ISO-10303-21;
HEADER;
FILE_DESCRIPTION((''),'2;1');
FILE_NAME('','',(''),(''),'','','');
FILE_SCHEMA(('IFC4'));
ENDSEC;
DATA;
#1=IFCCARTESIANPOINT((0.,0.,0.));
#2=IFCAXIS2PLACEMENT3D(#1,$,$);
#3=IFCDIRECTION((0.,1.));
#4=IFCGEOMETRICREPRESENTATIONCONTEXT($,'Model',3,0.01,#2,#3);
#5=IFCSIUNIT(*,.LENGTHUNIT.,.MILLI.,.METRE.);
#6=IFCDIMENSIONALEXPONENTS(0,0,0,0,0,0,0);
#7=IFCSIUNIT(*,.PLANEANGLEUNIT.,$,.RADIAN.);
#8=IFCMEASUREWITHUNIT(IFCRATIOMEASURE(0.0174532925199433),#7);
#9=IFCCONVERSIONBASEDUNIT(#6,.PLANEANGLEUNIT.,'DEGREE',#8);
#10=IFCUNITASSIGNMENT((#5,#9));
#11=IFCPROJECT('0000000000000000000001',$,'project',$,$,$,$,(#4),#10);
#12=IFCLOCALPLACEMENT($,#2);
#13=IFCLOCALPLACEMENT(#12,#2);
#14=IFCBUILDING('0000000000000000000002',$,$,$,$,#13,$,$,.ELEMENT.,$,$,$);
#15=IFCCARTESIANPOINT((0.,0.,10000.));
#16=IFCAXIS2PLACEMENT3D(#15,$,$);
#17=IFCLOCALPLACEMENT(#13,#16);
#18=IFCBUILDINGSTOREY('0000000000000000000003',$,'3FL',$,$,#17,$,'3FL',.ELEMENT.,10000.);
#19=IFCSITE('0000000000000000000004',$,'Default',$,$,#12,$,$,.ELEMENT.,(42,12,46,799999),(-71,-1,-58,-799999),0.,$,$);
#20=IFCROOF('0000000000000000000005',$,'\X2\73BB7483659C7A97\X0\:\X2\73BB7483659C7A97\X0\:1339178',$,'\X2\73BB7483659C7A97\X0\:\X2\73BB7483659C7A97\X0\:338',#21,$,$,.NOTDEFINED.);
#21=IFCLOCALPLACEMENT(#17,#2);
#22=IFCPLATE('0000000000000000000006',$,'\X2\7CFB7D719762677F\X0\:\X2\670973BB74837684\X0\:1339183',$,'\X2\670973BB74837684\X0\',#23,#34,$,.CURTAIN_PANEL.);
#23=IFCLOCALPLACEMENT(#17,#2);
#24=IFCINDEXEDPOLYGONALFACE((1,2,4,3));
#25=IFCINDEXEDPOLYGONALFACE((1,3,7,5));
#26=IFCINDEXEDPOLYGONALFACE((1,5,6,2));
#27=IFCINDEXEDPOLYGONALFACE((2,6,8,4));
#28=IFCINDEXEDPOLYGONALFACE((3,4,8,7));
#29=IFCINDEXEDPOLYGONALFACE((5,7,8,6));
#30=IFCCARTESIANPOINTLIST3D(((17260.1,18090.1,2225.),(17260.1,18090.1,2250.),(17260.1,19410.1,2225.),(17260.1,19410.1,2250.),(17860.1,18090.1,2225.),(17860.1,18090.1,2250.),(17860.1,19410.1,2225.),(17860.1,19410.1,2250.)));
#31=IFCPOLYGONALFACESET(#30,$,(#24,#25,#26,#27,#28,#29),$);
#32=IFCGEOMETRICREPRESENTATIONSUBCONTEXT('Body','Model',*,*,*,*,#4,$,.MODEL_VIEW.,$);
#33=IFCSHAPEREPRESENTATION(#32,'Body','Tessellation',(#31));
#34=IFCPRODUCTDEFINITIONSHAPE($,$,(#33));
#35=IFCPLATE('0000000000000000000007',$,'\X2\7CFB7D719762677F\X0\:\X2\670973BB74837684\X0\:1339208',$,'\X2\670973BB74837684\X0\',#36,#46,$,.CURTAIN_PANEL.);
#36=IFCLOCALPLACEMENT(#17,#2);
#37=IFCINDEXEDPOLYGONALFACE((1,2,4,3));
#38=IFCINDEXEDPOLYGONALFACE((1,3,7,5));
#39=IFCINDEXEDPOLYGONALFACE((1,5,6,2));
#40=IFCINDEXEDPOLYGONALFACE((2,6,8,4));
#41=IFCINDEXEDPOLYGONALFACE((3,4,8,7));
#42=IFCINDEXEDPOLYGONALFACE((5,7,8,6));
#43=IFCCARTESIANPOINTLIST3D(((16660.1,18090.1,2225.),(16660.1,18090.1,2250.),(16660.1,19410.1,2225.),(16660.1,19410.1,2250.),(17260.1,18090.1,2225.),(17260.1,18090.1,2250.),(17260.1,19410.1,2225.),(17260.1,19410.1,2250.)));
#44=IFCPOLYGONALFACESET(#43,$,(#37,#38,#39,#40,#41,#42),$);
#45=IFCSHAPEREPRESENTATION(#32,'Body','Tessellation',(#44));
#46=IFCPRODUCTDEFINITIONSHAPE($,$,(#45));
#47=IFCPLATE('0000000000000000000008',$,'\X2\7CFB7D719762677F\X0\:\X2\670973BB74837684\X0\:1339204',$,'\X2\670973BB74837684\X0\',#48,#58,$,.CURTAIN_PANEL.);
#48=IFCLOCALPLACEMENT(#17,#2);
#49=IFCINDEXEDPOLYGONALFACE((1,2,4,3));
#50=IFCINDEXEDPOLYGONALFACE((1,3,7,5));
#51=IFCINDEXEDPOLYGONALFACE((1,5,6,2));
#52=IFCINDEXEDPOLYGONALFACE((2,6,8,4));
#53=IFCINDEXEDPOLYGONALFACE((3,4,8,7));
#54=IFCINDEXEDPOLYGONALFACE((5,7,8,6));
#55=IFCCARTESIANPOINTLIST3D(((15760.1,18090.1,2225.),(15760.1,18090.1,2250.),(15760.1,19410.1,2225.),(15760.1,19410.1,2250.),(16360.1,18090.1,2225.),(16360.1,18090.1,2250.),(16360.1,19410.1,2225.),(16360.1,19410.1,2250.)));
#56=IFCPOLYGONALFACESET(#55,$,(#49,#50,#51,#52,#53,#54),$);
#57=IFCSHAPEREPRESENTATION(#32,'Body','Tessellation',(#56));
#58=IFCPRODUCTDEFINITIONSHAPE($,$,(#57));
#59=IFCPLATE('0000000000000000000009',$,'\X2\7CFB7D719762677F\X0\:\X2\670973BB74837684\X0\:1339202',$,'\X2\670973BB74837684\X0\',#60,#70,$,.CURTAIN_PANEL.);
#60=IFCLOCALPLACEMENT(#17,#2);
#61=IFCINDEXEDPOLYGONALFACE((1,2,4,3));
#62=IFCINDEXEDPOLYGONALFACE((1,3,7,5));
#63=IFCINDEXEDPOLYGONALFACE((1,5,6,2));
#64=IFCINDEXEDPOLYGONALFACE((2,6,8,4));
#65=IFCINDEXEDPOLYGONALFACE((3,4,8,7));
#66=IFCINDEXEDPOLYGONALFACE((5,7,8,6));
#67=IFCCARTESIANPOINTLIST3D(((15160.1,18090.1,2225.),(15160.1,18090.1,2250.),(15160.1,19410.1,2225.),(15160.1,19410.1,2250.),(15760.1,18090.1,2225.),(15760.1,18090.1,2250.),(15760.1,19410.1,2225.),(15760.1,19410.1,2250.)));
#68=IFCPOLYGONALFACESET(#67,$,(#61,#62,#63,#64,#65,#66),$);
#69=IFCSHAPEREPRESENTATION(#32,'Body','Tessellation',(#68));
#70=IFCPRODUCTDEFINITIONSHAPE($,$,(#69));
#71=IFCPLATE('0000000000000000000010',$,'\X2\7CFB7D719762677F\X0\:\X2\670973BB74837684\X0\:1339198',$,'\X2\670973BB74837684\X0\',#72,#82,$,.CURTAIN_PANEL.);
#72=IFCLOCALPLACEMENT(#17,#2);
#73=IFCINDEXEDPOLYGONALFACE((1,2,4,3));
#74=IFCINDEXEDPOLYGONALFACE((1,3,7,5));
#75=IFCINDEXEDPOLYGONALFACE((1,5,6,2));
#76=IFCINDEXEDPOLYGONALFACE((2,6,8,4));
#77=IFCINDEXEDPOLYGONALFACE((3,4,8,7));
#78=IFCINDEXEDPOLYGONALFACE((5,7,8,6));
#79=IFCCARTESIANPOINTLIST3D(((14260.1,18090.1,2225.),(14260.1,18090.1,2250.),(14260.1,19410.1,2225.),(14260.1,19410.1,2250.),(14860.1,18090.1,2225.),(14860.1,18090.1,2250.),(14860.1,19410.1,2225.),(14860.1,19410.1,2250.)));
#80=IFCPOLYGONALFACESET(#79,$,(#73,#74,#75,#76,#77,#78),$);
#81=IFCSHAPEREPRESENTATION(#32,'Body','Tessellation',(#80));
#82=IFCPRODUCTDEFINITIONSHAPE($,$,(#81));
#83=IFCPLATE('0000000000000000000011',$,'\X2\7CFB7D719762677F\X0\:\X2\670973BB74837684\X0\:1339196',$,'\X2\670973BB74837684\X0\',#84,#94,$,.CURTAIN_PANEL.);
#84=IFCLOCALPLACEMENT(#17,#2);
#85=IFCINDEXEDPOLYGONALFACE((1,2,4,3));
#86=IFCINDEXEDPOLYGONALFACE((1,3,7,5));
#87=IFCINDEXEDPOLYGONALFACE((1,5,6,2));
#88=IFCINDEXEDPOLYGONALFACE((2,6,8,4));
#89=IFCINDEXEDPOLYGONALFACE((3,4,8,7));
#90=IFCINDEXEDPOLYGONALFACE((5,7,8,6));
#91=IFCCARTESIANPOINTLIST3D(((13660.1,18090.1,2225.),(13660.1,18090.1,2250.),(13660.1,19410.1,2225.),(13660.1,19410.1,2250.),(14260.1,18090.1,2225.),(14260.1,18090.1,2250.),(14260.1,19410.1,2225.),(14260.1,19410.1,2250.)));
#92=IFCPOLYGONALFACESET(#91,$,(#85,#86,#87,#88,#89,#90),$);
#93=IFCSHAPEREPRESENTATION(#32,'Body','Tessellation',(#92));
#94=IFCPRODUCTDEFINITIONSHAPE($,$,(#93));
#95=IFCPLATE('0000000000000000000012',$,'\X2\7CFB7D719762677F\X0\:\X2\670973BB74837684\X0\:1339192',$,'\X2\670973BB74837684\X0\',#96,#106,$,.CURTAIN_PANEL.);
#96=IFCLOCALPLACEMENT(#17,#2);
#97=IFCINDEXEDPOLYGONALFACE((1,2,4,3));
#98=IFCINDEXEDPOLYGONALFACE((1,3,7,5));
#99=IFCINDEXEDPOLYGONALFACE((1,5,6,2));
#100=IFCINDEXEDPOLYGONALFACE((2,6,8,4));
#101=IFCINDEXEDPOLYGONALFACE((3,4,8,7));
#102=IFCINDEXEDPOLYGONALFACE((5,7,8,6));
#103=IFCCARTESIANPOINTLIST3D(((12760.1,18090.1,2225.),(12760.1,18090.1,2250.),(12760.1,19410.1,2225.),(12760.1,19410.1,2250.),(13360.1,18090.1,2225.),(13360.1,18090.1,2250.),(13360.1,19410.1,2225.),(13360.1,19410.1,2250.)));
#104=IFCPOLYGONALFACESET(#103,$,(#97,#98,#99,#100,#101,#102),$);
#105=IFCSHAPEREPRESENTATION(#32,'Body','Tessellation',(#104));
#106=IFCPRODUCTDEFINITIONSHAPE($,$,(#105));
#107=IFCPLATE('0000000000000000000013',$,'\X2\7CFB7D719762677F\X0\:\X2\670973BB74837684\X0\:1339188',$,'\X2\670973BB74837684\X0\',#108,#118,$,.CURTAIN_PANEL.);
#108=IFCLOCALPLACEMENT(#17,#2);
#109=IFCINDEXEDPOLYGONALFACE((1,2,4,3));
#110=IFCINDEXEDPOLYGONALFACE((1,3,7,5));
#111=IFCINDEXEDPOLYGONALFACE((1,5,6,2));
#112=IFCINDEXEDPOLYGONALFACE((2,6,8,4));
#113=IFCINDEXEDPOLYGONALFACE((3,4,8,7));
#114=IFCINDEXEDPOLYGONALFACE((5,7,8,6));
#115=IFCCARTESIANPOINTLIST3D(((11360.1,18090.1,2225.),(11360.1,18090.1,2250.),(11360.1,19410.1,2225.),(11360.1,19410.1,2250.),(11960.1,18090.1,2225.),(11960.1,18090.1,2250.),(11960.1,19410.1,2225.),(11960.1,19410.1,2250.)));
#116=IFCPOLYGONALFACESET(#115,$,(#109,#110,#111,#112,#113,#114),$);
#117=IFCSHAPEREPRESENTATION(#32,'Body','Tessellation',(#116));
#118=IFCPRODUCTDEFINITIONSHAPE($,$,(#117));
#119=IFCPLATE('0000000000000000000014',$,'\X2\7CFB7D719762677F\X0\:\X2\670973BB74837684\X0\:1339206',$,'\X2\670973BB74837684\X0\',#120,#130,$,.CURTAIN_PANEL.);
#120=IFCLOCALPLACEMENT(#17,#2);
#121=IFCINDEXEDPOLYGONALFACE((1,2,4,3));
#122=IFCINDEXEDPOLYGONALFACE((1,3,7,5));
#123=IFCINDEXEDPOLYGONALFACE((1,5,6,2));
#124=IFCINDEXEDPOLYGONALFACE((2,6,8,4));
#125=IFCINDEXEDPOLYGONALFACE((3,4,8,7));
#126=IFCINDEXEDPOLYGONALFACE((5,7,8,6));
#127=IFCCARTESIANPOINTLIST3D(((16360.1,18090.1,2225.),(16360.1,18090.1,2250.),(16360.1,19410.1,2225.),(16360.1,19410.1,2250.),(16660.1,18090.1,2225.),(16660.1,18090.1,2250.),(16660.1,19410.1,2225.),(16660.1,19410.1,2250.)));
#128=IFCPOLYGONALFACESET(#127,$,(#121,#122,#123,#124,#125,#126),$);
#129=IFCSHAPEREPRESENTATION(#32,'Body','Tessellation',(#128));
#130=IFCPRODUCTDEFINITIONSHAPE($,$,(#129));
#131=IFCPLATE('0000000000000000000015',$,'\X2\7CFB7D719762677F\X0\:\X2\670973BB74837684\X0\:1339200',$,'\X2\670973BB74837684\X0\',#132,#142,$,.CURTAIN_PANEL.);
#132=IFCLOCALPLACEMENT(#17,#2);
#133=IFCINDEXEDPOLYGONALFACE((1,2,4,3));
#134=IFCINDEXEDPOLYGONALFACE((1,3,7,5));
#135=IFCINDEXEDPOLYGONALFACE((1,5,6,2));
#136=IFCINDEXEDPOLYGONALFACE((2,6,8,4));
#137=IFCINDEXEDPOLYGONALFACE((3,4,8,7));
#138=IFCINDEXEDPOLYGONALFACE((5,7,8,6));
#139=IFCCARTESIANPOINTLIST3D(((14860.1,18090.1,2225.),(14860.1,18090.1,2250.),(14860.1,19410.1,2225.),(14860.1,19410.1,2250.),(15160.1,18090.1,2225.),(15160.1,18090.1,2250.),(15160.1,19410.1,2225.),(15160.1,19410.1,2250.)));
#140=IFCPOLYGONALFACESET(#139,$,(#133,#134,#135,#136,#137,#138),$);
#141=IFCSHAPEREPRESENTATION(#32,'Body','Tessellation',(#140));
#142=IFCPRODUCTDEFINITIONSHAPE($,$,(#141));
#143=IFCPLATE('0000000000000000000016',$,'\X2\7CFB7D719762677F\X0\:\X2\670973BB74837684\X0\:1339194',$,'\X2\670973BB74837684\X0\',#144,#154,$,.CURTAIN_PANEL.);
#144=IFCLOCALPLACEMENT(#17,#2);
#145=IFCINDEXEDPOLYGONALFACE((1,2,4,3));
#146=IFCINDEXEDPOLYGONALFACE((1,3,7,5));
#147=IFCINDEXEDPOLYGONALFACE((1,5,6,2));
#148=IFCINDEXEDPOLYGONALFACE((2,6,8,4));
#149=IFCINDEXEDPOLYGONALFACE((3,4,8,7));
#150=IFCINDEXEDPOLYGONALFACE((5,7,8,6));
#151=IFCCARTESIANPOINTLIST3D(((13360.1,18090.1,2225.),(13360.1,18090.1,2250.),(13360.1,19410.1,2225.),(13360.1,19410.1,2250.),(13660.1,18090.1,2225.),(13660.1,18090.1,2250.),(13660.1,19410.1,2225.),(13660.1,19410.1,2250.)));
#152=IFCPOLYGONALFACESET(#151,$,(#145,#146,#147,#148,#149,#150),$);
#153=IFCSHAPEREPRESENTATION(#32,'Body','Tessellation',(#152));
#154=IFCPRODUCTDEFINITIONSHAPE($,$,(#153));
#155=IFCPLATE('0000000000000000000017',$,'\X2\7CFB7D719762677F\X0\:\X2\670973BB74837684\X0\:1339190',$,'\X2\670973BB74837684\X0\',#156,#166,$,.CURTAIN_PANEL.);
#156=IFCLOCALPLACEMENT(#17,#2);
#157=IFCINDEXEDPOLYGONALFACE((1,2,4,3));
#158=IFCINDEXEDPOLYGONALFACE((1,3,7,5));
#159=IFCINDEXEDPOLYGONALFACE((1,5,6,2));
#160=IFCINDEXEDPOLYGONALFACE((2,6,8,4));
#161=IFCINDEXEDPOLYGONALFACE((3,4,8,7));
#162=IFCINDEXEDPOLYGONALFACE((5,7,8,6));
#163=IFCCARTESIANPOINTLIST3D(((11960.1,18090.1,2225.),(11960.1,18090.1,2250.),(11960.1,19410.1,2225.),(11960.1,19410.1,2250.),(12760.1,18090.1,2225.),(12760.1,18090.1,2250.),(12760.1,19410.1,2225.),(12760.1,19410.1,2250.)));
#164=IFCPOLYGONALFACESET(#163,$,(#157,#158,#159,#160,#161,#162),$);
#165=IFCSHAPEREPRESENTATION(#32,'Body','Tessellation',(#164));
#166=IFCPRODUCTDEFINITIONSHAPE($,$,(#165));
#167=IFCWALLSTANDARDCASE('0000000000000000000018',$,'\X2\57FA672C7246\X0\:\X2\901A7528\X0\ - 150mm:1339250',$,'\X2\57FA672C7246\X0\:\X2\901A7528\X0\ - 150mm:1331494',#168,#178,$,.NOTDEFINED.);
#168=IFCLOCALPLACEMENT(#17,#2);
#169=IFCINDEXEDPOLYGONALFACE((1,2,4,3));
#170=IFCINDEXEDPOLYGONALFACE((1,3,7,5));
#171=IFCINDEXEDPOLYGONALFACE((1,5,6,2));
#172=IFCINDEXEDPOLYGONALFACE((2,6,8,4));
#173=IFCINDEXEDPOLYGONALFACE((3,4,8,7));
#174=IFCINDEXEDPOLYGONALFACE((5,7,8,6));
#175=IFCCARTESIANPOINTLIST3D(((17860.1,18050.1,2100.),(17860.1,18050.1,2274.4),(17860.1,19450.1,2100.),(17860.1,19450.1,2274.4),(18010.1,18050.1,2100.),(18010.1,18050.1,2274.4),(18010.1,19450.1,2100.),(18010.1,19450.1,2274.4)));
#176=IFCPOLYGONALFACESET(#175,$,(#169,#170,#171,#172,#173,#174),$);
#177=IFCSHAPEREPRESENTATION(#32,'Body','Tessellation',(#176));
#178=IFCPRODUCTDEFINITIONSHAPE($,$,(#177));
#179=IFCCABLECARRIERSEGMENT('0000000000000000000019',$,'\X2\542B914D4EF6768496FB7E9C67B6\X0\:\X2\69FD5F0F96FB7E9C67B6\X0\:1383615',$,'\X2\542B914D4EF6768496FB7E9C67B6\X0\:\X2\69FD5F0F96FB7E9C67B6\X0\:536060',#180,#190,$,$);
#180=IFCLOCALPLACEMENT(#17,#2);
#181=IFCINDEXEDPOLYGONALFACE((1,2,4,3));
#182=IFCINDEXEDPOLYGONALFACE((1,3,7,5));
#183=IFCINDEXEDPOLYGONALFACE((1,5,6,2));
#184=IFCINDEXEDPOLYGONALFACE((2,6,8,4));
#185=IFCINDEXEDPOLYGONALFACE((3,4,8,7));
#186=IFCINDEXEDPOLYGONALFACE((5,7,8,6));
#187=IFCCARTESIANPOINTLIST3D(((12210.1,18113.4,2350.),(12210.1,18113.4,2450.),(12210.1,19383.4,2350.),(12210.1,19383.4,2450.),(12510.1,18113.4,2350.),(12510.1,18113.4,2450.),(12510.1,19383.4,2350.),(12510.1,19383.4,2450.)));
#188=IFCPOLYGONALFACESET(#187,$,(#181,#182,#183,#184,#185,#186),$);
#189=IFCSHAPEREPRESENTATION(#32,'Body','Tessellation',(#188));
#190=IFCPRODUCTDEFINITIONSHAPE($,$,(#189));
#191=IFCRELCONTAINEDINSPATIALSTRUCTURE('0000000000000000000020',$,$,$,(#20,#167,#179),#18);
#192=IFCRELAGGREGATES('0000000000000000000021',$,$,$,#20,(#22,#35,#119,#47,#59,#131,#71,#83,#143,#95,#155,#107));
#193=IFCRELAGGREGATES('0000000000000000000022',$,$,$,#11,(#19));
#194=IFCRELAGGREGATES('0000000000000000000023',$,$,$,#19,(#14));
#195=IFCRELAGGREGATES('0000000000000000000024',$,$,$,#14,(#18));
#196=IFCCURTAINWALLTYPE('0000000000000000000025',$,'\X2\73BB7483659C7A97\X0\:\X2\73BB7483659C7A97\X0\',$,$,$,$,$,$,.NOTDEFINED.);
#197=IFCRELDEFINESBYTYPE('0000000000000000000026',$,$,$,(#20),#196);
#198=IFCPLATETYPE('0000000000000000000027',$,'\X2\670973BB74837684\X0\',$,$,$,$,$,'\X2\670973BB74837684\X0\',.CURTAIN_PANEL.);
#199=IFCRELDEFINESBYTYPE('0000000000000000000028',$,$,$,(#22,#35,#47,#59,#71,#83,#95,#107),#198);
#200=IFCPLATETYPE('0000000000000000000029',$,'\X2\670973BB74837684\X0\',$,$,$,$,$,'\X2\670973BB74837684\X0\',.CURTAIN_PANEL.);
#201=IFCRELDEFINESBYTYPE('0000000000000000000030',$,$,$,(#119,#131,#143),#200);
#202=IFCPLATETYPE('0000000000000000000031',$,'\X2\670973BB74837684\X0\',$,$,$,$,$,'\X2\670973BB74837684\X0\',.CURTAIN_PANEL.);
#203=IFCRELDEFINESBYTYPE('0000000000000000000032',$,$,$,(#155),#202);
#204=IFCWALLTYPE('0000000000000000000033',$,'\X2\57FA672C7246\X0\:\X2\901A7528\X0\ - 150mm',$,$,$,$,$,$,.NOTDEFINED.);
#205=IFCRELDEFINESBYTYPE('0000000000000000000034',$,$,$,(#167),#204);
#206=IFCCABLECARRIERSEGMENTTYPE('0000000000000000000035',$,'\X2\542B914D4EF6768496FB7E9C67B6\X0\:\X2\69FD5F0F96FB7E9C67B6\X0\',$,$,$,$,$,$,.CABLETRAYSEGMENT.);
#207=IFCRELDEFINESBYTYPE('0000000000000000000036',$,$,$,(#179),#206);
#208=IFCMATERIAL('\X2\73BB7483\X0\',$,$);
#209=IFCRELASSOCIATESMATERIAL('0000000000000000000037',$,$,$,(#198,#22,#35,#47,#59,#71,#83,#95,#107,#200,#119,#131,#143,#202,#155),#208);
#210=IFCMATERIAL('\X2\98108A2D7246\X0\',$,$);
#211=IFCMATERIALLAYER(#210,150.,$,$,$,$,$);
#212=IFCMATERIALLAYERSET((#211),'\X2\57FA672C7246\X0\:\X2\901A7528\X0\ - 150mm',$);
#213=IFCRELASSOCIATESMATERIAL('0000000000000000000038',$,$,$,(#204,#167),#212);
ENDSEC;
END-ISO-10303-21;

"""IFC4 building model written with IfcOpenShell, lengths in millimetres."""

from ifc_helpers import new_model, entity, si_unit, converted_unit, direction, frame, frame_2d, origin, origin_2d_with_axis, place, context, subcontext, project, spatial, rectangle, extrude, source, transform, mapped, material, layer, layer_set, layer_usage, type_object, type_shapes, element, aggregate, save


model = new_model("IFC4")

# Units and contexts
model_context = context("Model", 3, precision=0.01, world=origin(), true_north=direction((0.0, 1.0)))
body_context = subcontext(model_context, "Body", "Model", "MODEL_VIEW")
ifc_project = project(units=[si_unit("LENGTHUNIT", "METRE", prefix="MILLI"), converted_unit("PLANEANGLEUNIT", "DEGREE", entity("IfcRatioMeasure", 0.0174532925199433), si_unit("PLANEANGLEUNIT", "RADIAN"), dimensions=[0, 0, 0, 0, 0, 0, 0])], contexts=[model_context])

# Site, building, storey
site_placement = place(None, origin())
site = spatial("IfcSite", under=ifc_project, at=site_placement, Name="Default", CompositionType="ELEMENT", RefLatitude=(42, 12, 46, 799999), RefLongitude=(-71, -1, -58, -799999), RefElevation=0.0)
building_placement = place(site_placement, origin())
building = spatial("IfcBuilding", under=site, at=building_placement, CompositionType="ELEMENT")
storey_placement = place(building_placement, frame((0.0, 0.0, 10000.0)))
storey = spatial("IfcBuildingStorey", under=building, at=storey_placement, Name="3FL", LongName="3FL", CompositionType="ELEMENT", Elevation=10000.0)

# Roof, plates
curtain_wall_type = type_object("IfcCurtainWallType", Name="玻璃斜窗:玻璃斜窗", PredefinedType="NOTDEFINED")
roof_placement = place(storey_placement, frame((0.0, 0.0, -10000.0)))
roof = element("IfcRoof", 1, at=roof_placement, inside=storey, type_object=curtain_wall_type, Name="玻璃斜窗:玻璃斜窗:1339178", ObjectType="玻璃斜窗:玻璃斜窗:338", PredefinedType="NOTDEFINED")
ifc_material_1 = material(Name="玻璃")
plate_type_1 = type_object("IfcPlateType", Name="有玻璃的", ElementType="有玻璃的", PredefinedType="CURTAIN_PANEL", material=ifc_material_1)
shared_shape_1 = source(origin(), body_context, "Body", "SweptSolid", [
    extrude(rectangle(XDim=25.0, YDim=600.0, at=origin_2d_with_axis()), frame((300.0, 12.5, 0.0), z_axis=(0.0, 0.0, 1.0), x_axis=(0.0, 1.0, 0.0)), (0.0, 0.0, 1.0), 1320.0),
])
type_shapes(plate_type_1, [shared_shape_1])
plate_1_placement = place(roof_placement, frame((17860.1, 19410.1, 12250.0), z_axis=(0.0, -1.0, 0.0), x_axis=(-1.0, 0.0, 0.0)))
plate_1 = element("IfcPlate", 2, at=plate_1_placement, type_object=plate_type_1, material=ifc_material_1, Name="系統面板:有玻璃的:1339183", ObjectType="有玻璃的", PredefinedType="CURTAIN_PANEL", context=body_context, shape_type="MappedRepresentation", body=[
    mapped(shared_shape_1, transform((0.0, 0.0, 0.0), scale=1.0)),
])
plate_2_placement = place(roof_placement, frame((17260.1, 19410.1, 12250.0), z_axis=(0.0, -1.0, 0.0), x_axis=(-1.0, 0.0, 0.0)))
plate_2 = element("IfcPlate", 3, at=plate_2_placement, type_object=plate_type_1, material=ifc_material_1, Name="系統面板:有玻璃的:1339208", ObjectType="有玻璃的", PredefinedType="CURTAIN_PANEL", context=body_context, shape_type="MappedRepresentation", body=[
    mapped(shared_shape_1, transform((0.0, 0.0, 0.0), scale=1.0)),
])
plate_3_placement = place(roof_placement, frame((16360.1, 19410.1, 12250.0), z_axis=(0.0, -1.0, 0.0), x_axis=(-1.0, 0.0, 0.0)))
plate_3 = element("IfcPlate", 4, at=plate_3_placement, type_object=plate_type_1, material=ifc_material_1, Name="系統面板:有玻璃的:1339204", ObjectType="有玻璃的", PredefinedType="CURTAIN_PANEL", context=body_context, shape_type="MappedRepresentation", body=[
    mapped(shared_shape_1, transform((0.0, 0.0, 0.0), scale=1.0)),
])
plate_4_placement = place(roof_placement, frame((15760.1, 19410.1, 12250.0), z_axis=(0.0, -1.0, 0.0), x_axis=(-1.0, 0.0, 0.0)))
plate_4 = element("IfcPlate", 5, at=plate_4_placement, type_object=plate_type_1, material=ifc_material_1, Name="系統面板:有玻璃的:1339202", ObjectType="有玻璃的", PredefinedType="CURTAIN_PANEL", context=body_context, shape_type="MappedRepresentation", body=[
    mapped(shared_shape_1, transform((0.0, 0.0, 0.0), scale=1.0)),
])
plate_5_placement = place(roof_placement, frame((14860.1, 19410.1, 12250.0), z_axis=(0.0, -1.0, 0.0), x_axis=(-1.0, 0.0, 0.0)))
plate_5 = element("IfcPlate", 6, at=plate_5_placement, type_object=plate_type_1, material=ifc_material_1, Name="系統面板:有玻璃的:1339198", ObjectType="有玻璃的", PredefinedType="CURTAIN_PANEL", context=body_context, shape_type="MappedRepresentation", body=[
    mapped(shared_shape_1, transform((0.0, 0.0, 0.0), scale=1.0)),
])
plate_6_placement = place(roof_placement, frame((14260.1, 19410.1, 12250.0), z_axis=(0.0, -1.0, 0.0), x_axis=(-1.0, 0.0, 0.0)))
plate_6 = element("IfcPlate", 7, at=plate_6_placement, type_object=plate_type_1, material=ifc_material_1, Name="系統面板:有玻璃的:1339196", ObjectType="有玻璃的", PredefinedType="CURTAIN_PANEL", context=body_context, shape_type="MappedRepresentation", body=[
    mapped(shared_shape_1, transform((0.0, 0.0, 0.0), scale=1.0)),
])
plate_7_placement = place(roof_placement, frame((13360.1, 19410.1, 12250.0), z_axis=(0.0, -1.0, 0.0), x_axis=(-1.0, 0.0, 0.0)))
plate_7 = element("IfcPlate", 8, at=plate_7_placement, type_object=plate_type_1, material=ifc_material_1, Name="系統面板:有玻璃的:1339192", ObjectType="有玻璃的", PredefinedType="CURTAIN_PANEL", context=body_context, shape_type="MappedRepresentation", body=[
    mapped(shared_shape_1, transform((0.0, 0.0, 0.0), scale=1.0)),
])
plate_8_placement = place(roof_placement, frame((11960.1, 19410.1, 12250.0), z_axis=(0.0, -1.0, 0.0), x_axis=(-1.0, 0.0, 0.0)))
plate_8 = element("IfcPlate", 9, at=plate_8_placement, type_object=plate_type_1, material=ifc_material_1, Name="系統面板:有玻璃的:1339188", ObjectType="有玻璃的", PredefinedType="CURTAIN_PANEL", context=body_context, shape_type="MappedRepresentation", body=[
    mapped(shared_shape_1, transform((0.0, 0.0, 0.0), scale=1.0)),
])
plate_type_2 = type_object("IfcPlateType", Name="有玻璃的", ElementType="有玻璃的", PredefinedType="CURTAIN_PANEL", material=ifc_material_1)
shared_shape_2 = source(origin(), body_context, "Body", "SweptSolid", [
    extrude(rectangle(XDim=25.0, YDim=300.0, at=origin_2d_with_axis()), frame((150.0, 12.5, 0.0), z_axis=(0.0, 0.0, 1.0), x_axis=(0.0, 1.0, 0.0)), (0.0, 0.0, 1.0), 1320.0),
])
type_shapes(plate_type_2, [shared_shape_2])
plate_9_placement = place(roof_placement, frame((16660.1, 19410.1, 12250.0), z_axis=(0.0, -1.0, 0.0), x_axis=(-1.0, 0.0, 0.0)))
plate_9 = element("IfcPlate", 10, at=plate_9_placement, type_object=plate_type_2, material=ifc_material_1, Name="系統面板:有玻璃的:1339206", ObjectType="有玻璃的", PredefinedType="CURTAIN_PANEL", context=body_context, shape_type="MappedRepresentation", body=[
    mapped(shared_shape_2, transform((0.0, 0.0, 0.0), scale=1.0)),
])
plate_10_placement = place(roof_placement, frame((15160.1, 19410.1, 12250.0), z_axis=(0.0, -1.0, 0.0), x_axis=(-1.0, 0.0, 0.0)))
plate_10 = element("IfcPlate", 11, at=plate_10_placement, type_object=plate_type_2, material=ifc_material_1, Name="系統面板:有玻璃的:1339200", ObjectType="有玻璃的", PredefinedType="CURTAIN_PANEL", context=body_context, shape_type="MappedRepresentation", body=[
    mapped(shared_shape_2, transform((0.0, 0.0, 0.0), scale=1.0)),
])
plate_11_placement = place(roof_placement, frame((13660.1, 19410.1, 12250.0), z_axis=(0.0, -1.0, 0.0), x_axis=(-1.0, 0.0, 0.0)))
plate_11 = element("IfcPlate", 12, at=plate_11_placement, type_object=plate_type_2, material=ifc_material_1, Name="系統面板:有玻璃的:1339194", ObjectType="有玻璃的", PredefinedType="CURTAIN_PANEL", context=body_context, shape_type="MappedRepresentation", body=[
    mapped(shared_shape_2, transform((0.0, 0.0, 0.0), scale=1.0)),
])
plate_type_3 = type_object("IfcPlateType", Name="有玻璃的", ElementType="有玻璃的", PredefinedType="CURTAIN_PANEL", material=ifc_material_1)
shared_shape_3 = source(origin(), body_context, "Body", "SweptSolid", [
    extrude(rectangle(XDim=25.0, YDim=800.0, at=origin_2d_with_axis()), frame((400.0, 12.5, 0.0), z_axis=(0.0, 0.0, 1.0), x_axis=(0.0, 1.0, 0.0)), (0.0, 0.0, 1.0), 1320.0),
])
type_shapes(plate_type_3, [shared_shape_3])
plate_12_placement = place(roof_placement, frame((12760.1, 19410.1, 12250.0), z_axis=(0.0, -1.0, 0.0), x_axis=(-1.0, 0.0, 0.0)))
plate_12 = element("IfcPlate", 13, at=plate_12_placement, type_object=plate_type_3, material=ifc_material_1, Name="系統面板:有玻璃的:1339190", ObjectType="有玻璃的", PredefinedType="CURTAIN_PANEL", context=body_context, shape_type="MappedRepresentation", body=[
    mapped(shared_shape_3, transform((0.0, 0.0, 0.0), scale=1.0)),
])
aggregate(roof, [plate_1, plate_2, plate_9, plate_3, plate_4, plate_10, plate_5, plate_6, plate_11, plate_7, plate_12, plate_8])

# Wall, opening
ifc_material_2 = material(Name="預設牆")
ifc_layer = layer(ifc_material_2, 150.0)
ifc_layer_set = layer_set([ifc_layer], Name="基本牆:通用 - 150mm")
ifc_layer_usage = layer_usage(ifc_layer_set, "AXIS2", "POSITIVE", -75.0)
wall_type = type_object("IfcWallType", Name="基本牆:通用 - 150mm", PredefinedType="NOTDEFINED", material=ifc_layer_set)
wall_placement = place(storey_placement, frame((17935.1, 19450.1, 2100.0), z_axis=(0.0, 0.0, 1.0), x_axis=(0.0, -1.0, 0.0)))
wall = element("IfcWallStandardCase", 14, at=wall_placement, inside=storey, type_object=wall_type, material=ifc_layer_usage, Name="基本牆:通用 - 150mm:1339250", ObjectType="基本牆:通用 - 150mm:1331494", PredefinedType="NOTDEFINED", context=body_context, shape_type="SweptSolid", body=[
    extrude(rectangle(XDim=1400.0, YDim=150.0, at=frame_2d((700.0, 0.0), x_axis=(-1.0, 0.0))), origin(), (0.0, 0.0, 1.0), 174.4),
])
opening_placement = place(wall_placement, frame((0.0, -75.0, -2100.0)))
element("IfcOpeningElement", 15, at=opening_placement, cuts=wall, ObjectType="Opening", PredefinedType="OPENING", context=body_context, shape_type="SweptSolid", body=[
    extrude(rectangle(XDim=2100.0, YDim=1400.0, at=frame_2d((1050.0, 700.0), x_axis=(1.0, 0.0))), frame((0.0, 0.0, 0.0), z_axis=(0.0, 1.0, 0.0), x_axis=(0.0, 0.0, 1.0)), (0.0, 0.0, 1.0), 150.0),
])

# Cable carrier segment
cable_carrier_segment_type_1 = type_object("IfcCableCarrierSegmentType", Name="含配件的電纜架:槽式電纜架", PredefinedType="CABLETRAYSEGMENT")
cable_carrier_segment_1_placement = place(storey_placement, frame((12210.1, 18113.4, 2350.0)))
element("IfcCableCarrierSegment", 16, at=cable_carrier_segment_1_placement, inside=storey, type_object=cable_carrier_segment_type_1, Name="含配件的電纜架:槽式電纜架:1383615", ObjectType="含配件的電纜架:槽式電纜架:536060", context=body_context, shape_type="SweptSolid", body=[
    extrude(rectangle(XDim=1270.0, YDim=300.0, at=origin_2d_with_axis()), frame((150.0, 635.0, 0.0), z_axis=(0.0, 0.0, 1.0), x_axis=(0.0, 1.0, 0.0)), (0.0, 0.0, 1.0), 100.0),
])

save(model, "model.ifc")
